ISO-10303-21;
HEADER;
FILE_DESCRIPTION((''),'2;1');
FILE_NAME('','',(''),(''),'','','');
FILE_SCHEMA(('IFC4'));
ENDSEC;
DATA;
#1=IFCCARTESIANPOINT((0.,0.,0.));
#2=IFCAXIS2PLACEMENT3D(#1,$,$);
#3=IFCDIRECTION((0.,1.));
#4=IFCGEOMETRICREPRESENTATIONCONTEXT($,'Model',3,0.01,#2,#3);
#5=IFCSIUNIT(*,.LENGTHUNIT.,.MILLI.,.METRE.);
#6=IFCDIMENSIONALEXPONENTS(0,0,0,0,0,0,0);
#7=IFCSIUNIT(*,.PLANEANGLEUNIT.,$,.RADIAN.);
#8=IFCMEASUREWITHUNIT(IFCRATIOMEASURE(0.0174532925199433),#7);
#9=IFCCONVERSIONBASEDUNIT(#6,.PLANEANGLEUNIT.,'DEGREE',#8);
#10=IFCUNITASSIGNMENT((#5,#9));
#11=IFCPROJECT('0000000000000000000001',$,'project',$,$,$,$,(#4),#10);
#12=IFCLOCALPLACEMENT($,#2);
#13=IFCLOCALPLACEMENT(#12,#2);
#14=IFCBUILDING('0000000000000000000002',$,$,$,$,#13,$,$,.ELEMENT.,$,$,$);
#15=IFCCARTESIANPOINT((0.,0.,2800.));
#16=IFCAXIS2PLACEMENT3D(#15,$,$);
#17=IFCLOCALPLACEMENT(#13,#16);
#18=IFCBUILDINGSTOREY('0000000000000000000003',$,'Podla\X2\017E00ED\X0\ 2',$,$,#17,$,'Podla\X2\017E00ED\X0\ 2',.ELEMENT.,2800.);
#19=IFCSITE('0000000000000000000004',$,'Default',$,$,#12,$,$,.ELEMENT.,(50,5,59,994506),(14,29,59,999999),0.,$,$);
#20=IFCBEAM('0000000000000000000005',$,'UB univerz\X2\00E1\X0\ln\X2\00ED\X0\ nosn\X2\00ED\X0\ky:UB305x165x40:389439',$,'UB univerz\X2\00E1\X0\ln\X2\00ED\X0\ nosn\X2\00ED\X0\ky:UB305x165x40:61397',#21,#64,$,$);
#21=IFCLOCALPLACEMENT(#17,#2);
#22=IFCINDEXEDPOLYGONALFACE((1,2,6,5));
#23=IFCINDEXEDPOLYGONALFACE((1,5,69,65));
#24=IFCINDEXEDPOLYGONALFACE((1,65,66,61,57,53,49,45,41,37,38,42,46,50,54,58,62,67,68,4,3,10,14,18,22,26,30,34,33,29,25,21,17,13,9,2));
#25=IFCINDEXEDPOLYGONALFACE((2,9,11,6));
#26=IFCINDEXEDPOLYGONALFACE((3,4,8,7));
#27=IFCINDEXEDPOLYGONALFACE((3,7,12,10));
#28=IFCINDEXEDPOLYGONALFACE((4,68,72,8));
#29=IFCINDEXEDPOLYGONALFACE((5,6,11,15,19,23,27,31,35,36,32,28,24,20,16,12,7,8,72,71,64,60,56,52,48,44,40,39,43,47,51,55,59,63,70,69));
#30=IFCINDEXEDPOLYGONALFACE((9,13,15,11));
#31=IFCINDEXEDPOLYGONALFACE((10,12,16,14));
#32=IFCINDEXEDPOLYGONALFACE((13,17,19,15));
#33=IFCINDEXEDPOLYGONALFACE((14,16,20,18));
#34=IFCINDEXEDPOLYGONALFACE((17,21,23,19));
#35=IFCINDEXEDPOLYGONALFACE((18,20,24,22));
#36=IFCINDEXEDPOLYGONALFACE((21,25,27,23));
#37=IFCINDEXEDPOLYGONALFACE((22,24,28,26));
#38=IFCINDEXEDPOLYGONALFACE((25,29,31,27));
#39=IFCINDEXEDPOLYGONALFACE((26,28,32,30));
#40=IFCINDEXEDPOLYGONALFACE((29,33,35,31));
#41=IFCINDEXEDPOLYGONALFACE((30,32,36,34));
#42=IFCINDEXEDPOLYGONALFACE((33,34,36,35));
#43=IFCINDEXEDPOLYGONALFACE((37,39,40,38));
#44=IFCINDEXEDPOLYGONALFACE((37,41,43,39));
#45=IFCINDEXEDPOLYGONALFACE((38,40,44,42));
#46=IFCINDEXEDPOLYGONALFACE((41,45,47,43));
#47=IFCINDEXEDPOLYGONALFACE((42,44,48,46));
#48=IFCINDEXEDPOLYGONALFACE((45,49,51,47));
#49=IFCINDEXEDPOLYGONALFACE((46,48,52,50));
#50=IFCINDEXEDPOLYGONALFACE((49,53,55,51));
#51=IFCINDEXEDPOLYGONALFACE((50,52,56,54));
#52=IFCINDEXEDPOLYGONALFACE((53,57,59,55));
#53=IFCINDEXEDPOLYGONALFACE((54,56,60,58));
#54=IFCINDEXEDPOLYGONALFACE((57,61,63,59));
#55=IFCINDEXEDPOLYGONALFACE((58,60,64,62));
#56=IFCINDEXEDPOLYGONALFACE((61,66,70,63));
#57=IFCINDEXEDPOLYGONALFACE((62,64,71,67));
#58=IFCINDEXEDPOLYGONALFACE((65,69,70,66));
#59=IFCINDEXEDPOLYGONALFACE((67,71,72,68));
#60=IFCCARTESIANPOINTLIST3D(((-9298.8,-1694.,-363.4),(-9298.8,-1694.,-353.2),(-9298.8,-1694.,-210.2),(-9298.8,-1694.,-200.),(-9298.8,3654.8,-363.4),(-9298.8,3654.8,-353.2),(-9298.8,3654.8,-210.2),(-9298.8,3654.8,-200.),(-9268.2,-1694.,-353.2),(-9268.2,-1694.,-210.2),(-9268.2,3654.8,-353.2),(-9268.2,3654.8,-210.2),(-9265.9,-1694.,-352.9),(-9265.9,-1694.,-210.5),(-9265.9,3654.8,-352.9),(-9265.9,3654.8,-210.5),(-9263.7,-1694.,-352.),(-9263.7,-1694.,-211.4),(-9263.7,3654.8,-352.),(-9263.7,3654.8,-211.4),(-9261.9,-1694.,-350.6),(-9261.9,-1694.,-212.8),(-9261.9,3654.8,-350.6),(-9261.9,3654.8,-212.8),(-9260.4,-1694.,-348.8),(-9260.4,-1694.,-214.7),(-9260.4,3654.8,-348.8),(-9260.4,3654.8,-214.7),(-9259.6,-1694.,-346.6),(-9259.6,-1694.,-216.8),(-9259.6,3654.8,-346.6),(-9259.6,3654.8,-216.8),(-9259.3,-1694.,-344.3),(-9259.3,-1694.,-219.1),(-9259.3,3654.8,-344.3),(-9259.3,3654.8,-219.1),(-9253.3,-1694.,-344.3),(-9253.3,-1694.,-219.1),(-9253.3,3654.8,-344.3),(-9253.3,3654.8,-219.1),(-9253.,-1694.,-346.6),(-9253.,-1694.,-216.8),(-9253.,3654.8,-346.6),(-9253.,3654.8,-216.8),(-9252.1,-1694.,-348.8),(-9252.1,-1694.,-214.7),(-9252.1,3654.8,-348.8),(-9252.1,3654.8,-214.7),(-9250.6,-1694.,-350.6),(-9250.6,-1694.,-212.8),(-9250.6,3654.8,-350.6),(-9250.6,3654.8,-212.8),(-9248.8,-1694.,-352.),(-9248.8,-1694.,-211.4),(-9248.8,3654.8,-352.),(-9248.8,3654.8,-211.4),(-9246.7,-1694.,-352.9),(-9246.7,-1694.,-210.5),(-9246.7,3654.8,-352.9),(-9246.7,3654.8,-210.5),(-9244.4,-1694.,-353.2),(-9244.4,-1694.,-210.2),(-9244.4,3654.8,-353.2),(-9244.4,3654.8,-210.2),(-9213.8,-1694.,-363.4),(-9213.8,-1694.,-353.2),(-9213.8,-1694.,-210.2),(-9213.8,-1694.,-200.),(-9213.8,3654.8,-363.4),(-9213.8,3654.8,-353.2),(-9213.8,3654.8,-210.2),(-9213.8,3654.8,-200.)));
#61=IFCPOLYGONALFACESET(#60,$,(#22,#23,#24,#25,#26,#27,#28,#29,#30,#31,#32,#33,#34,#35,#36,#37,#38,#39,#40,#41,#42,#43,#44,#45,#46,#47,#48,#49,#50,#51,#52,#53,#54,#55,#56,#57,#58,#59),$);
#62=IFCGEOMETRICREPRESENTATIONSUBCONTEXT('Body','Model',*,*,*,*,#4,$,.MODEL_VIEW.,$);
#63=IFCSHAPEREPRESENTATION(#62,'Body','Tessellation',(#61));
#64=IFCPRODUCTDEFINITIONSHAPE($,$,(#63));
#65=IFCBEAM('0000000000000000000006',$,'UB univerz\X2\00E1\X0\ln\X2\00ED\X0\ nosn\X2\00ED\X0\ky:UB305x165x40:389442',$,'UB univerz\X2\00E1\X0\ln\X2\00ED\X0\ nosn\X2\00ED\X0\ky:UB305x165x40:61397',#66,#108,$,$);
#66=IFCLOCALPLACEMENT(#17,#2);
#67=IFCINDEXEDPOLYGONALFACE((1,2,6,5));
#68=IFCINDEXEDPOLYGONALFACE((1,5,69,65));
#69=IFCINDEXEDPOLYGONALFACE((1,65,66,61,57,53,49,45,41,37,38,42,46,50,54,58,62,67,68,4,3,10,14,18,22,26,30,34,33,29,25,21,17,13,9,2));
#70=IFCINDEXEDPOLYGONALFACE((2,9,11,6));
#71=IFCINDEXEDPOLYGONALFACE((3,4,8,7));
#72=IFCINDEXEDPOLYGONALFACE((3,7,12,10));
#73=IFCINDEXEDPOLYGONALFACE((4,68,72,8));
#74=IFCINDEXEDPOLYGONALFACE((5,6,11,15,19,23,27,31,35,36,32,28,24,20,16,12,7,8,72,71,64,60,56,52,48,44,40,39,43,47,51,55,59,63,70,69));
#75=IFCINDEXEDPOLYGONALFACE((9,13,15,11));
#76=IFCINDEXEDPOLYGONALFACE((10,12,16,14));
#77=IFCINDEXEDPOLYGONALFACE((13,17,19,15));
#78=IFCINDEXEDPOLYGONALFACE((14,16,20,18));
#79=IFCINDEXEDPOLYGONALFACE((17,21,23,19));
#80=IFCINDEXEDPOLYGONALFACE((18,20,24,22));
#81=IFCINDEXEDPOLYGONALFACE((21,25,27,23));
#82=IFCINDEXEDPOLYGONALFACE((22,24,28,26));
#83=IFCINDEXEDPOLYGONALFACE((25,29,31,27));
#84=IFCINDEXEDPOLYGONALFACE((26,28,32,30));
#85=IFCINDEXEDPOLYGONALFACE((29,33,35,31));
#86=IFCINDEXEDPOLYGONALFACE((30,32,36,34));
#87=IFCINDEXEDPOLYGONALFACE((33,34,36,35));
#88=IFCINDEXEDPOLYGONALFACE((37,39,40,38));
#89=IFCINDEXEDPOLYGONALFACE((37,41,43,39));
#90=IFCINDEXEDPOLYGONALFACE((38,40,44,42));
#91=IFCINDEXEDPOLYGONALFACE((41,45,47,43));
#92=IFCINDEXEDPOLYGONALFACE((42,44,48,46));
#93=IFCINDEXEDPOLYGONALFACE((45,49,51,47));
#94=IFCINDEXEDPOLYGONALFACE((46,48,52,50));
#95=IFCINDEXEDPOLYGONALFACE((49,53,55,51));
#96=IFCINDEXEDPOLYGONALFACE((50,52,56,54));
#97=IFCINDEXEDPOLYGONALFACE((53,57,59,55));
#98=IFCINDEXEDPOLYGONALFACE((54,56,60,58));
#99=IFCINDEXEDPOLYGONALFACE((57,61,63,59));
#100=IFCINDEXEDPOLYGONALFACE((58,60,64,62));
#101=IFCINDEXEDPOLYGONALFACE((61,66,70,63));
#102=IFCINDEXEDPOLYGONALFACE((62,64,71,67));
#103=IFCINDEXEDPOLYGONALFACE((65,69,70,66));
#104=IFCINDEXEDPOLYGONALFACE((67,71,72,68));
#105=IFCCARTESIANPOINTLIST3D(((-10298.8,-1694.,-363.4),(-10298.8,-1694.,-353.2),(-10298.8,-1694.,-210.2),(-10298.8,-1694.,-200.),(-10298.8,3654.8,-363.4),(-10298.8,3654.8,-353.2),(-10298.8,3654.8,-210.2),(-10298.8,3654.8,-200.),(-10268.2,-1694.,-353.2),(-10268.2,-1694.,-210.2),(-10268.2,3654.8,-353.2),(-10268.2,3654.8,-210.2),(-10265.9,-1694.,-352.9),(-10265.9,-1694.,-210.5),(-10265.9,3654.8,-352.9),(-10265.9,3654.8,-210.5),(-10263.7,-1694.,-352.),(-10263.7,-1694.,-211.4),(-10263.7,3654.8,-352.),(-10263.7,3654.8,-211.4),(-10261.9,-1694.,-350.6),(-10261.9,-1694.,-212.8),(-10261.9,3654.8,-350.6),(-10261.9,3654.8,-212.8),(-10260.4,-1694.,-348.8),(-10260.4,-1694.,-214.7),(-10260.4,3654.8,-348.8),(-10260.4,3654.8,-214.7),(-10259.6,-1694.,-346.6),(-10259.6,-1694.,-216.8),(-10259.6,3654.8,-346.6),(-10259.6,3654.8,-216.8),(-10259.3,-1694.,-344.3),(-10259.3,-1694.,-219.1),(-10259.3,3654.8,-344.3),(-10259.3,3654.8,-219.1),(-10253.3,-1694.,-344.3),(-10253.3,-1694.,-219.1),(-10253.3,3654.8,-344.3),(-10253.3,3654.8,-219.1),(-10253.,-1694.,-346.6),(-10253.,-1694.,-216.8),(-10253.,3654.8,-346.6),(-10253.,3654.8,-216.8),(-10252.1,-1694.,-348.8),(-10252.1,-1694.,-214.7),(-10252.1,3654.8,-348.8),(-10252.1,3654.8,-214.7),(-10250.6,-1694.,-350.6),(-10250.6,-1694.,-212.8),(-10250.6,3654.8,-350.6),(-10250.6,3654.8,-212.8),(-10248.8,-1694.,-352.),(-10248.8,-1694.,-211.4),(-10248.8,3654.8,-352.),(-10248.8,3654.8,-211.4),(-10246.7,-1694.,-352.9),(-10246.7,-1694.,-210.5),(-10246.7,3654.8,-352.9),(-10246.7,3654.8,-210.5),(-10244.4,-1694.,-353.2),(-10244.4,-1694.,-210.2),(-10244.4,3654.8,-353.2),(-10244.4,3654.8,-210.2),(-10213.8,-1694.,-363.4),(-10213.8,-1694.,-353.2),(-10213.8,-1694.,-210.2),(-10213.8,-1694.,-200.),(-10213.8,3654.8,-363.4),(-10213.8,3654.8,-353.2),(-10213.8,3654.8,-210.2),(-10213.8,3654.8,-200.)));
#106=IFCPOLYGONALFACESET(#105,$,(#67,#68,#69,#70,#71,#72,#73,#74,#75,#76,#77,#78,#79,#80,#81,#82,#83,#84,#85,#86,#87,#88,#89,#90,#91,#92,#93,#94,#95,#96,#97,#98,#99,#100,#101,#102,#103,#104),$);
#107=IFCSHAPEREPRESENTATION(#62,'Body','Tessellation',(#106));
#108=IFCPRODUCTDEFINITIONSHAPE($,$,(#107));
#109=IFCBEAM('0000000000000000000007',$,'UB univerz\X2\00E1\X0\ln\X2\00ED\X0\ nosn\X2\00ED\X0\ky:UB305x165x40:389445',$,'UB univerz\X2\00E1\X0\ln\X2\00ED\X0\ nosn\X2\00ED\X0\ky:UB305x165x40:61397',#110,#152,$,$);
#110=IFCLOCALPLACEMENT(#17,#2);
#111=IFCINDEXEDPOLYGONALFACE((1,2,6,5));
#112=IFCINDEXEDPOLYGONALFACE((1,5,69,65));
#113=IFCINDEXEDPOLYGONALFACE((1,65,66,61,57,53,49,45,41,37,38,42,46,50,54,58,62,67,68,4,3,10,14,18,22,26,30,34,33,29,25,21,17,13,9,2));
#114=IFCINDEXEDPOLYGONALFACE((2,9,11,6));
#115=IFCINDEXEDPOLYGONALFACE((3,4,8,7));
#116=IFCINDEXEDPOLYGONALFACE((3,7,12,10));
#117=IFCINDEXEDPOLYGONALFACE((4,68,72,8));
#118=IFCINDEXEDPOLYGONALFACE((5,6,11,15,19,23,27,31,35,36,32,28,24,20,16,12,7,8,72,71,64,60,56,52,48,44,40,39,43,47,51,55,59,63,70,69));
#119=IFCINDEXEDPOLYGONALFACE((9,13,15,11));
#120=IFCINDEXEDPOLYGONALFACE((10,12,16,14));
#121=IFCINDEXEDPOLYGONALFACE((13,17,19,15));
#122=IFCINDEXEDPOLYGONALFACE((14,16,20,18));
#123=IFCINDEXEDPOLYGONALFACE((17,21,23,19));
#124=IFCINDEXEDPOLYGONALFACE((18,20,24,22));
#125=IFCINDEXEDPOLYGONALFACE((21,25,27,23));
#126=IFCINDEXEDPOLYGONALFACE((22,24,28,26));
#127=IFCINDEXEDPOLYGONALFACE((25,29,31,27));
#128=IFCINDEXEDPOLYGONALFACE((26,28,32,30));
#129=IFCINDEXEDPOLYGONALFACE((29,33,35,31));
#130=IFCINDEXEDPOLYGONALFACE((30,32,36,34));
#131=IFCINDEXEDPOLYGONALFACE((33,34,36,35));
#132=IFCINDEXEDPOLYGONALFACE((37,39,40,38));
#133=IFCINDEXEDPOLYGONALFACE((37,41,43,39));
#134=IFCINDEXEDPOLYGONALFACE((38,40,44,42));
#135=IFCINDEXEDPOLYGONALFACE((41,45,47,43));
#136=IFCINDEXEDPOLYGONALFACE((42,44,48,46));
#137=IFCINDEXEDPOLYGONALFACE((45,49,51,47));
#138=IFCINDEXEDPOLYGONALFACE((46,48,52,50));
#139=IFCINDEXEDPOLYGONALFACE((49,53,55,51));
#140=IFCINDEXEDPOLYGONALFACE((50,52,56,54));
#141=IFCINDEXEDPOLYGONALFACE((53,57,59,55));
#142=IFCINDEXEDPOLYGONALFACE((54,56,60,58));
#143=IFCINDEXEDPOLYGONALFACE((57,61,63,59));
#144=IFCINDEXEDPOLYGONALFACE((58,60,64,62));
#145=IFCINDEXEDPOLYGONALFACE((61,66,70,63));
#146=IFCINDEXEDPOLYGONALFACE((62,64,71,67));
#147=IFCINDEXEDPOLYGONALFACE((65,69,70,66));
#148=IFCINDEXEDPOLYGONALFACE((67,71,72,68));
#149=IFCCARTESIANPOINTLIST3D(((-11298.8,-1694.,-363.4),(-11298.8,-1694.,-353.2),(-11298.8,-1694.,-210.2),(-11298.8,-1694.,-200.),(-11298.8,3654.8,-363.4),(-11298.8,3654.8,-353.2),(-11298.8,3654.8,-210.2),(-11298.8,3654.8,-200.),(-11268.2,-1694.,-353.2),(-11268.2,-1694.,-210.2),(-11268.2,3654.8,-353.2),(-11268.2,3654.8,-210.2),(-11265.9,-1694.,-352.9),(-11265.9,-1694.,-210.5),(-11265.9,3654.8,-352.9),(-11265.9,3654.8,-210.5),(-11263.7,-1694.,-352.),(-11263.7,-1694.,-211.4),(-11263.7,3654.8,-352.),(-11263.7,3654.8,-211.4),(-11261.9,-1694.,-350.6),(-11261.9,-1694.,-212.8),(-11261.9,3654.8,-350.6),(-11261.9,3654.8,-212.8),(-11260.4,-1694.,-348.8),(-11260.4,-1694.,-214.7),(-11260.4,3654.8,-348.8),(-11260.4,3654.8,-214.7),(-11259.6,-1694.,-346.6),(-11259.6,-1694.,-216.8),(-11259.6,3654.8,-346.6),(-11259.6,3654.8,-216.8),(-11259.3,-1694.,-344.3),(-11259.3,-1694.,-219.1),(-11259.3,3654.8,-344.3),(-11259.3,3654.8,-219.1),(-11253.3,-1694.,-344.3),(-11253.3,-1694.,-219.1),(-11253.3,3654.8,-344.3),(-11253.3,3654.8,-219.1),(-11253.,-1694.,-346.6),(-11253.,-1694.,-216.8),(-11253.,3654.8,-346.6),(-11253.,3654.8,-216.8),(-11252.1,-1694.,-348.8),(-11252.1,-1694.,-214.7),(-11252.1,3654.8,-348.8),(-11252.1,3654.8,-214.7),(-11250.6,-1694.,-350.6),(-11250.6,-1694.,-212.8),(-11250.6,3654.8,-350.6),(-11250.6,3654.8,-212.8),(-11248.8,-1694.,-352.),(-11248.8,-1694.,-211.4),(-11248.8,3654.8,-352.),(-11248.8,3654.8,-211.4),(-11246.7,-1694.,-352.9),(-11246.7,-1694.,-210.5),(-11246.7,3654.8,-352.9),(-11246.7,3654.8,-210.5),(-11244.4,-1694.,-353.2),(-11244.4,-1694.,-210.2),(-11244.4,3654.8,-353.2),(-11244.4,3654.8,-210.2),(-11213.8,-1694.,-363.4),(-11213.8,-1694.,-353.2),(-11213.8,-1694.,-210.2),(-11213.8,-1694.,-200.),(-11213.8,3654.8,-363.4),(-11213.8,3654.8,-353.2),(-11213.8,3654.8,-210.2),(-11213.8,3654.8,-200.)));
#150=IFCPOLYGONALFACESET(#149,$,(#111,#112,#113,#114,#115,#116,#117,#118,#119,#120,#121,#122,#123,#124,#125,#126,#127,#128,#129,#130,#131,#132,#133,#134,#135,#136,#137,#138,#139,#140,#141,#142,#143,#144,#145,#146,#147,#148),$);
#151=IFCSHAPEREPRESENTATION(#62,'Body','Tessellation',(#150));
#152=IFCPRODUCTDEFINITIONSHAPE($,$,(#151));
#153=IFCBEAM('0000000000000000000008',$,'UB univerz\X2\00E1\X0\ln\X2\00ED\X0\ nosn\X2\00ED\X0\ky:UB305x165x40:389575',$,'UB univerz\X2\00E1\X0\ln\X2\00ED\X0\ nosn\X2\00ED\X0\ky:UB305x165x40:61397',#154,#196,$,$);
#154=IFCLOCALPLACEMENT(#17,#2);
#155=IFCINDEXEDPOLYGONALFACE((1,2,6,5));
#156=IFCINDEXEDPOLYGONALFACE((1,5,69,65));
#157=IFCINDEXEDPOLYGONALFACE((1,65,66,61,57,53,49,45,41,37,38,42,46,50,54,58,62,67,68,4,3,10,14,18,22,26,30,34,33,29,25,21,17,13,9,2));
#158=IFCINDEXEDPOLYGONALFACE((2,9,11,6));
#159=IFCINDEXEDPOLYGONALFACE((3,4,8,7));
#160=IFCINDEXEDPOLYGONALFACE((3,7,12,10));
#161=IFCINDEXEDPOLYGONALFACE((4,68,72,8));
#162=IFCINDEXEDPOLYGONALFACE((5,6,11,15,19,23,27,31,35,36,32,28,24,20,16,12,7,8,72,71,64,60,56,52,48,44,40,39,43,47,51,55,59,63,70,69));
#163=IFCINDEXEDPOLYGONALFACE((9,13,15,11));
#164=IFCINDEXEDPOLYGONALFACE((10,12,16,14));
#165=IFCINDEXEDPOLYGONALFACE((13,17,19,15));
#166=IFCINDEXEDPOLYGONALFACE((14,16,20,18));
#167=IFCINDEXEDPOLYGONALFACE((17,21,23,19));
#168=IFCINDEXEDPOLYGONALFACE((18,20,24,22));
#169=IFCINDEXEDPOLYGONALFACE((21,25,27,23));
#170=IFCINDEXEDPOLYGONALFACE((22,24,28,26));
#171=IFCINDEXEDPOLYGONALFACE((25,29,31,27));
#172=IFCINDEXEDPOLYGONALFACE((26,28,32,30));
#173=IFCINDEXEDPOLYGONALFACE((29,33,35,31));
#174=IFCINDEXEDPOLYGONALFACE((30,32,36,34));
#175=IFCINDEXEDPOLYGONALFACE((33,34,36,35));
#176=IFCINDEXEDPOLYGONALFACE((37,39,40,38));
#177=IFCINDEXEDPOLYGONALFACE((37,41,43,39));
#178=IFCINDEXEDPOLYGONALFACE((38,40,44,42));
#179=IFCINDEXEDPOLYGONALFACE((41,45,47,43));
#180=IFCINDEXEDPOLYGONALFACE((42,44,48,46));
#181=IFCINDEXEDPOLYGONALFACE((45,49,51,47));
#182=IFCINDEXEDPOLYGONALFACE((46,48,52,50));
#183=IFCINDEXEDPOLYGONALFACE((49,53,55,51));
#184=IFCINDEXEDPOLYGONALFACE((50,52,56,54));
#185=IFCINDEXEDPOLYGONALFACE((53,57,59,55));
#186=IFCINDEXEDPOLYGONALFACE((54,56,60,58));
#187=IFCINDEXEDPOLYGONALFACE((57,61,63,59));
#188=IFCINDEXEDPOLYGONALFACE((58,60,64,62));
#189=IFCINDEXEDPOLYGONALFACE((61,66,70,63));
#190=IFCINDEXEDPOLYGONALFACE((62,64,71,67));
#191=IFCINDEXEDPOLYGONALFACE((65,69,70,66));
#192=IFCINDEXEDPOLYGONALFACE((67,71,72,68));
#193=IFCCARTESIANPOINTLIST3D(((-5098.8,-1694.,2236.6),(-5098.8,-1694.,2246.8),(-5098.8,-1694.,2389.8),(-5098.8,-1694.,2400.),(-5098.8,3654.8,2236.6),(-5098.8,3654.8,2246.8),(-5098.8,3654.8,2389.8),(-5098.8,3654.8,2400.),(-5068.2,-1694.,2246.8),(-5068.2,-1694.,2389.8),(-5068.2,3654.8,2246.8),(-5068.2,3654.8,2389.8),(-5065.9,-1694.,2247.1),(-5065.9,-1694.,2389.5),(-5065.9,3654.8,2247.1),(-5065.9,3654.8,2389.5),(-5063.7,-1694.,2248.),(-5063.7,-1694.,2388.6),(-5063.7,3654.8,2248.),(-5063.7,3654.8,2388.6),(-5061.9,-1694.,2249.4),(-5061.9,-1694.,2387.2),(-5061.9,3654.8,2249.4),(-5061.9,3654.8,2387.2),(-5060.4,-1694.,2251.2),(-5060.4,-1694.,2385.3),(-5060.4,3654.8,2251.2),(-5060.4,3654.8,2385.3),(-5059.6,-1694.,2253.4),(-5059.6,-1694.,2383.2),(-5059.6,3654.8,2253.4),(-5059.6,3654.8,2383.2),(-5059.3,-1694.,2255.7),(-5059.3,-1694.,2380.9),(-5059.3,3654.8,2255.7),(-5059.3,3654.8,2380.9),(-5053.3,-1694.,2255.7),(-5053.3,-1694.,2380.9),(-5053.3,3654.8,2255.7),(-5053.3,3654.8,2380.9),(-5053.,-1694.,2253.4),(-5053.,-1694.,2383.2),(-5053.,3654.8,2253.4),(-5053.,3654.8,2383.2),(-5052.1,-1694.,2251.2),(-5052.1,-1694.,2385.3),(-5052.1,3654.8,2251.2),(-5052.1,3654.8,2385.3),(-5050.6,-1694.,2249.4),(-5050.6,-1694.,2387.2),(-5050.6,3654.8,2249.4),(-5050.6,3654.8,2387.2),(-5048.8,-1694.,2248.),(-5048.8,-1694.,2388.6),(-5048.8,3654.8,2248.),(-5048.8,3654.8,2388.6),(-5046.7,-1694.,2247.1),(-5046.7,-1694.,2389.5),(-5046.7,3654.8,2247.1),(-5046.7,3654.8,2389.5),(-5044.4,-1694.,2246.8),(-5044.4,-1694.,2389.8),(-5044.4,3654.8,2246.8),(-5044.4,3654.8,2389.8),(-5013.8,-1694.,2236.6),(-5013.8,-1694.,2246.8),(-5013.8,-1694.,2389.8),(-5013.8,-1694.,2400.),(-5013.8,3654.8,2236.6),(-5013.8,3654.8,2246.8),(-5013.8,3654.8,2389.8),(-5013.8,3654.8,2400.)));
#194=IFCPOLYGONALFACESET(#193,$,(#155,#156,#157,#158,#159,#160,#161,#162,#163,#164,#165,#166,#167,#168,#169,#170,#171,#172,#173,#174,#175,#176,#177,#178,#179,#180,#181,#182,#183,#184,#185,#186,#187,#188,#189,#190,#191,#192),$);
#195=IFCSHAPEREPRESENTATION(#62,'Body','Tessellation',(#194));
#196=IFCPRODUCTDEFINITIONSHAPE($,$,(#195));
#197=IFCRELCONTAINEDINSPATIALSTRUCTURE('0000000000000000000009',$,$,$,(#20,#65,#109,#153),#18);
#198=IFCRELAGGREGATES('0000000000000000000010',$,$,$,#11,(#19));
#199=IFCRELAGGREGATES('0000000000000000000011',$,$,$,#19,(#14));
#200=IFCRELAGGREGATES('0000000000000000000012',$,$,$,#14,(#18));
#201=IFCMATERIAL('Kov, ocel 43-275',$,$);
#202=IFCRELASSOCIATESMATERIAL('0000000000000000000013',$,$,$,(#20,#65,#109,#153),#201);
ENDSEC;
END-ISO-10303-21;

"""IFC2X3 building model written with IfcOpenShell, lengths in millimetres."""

from ifc_helpers import new_model, entity, si_unit, converted_unit, direction, frame, frame_2d, origin, place, context, subcontext, project, spatial, i_section, extrude, material, element, save


model = new_model("IFC2X3")

# Units and contexts
model_context = context("Model", 3, precision=0.01, world=origin(), true_north=direction((0.0, 1.0)))
body_context = subcontext(model_context, "Body", "Model", "MODEL_VIEW")
ifc_project = project(units=[si_unit("LENGTHUNIT", "METRE", prefix="MILLI"), converted_unit("PLANEANGLEUNIT", "DEGREE", entity("IfcRatioMeasure", 0.0174532925199433), si_unit("PLANEANGLEUNIT", "RADIAN"), dimensions=[0, 0, 0, 0, 0, 0, 0])], contexts=[model_context])

# Site, building, storey
site_placement = place(None, origin())
site = spatial("IfcSite", under=ifc_project, at=site_placement, Name="Default", CompositionType="ELEMENT", RefLatitude=(50, 5, 59, 994506), RefLongitude=(14, 29, 59, 999999), RefElevation=0.0)
building_placement = place(site_placement, origin())
building = spatial("IfcBuilding", under=site, at=building_placement, CompositionType="ELEMENT")
storey_placement = place(building_placement, frame((0.0, 0.0, 2800.0)))
storey = spatial("IfcBuildingStorey", under=building, at=storey_placement, Name="Podlaží 2", LongName="Podlaží 2", CompositionType="ELEMENT", Elevation=2800.0)

# Beams
ifc_material = material(Name="Kov, ocel 43-275")
for number, where, z_axis, x_axis, name in (
    (1, (-9256.3, 3654.8, 0.0), (0.0, 0.0, 1.0), (0.0, -1.0, 0.0), "UB univerzální nosníky:UB305x165x40:389439"),
):
    element("IfcBeam", number, at=place(storey_placement, frame(where, z_axis=z_axis, x_axis=x_axis)), inside=storey, material=ifc_material, Name=name, ObjectType="UB univerzální nosníky:UB305x165x40:61397", context=body_context, shape_type="SweptSolid", body=[
        extrude(i_section(OverallWidth=85.0, OverallDepth=163.4, WebThickness=6.0, FlangeThickness=10.2, FilletRadius=8.9, at=frame_2d((0.0, 0.0), x_axis=(0.0, 1.0))), frame((0.0, 0.0, -281.7), z_axis=(1.0, 0.0, 0.0), x_axis=(0.0, 0.0, -1.0)), (0.0, 0.0, 1.0), 5348.8),
    ])
beam_1_placement = place(storey_placement, frame((-10256.3, 3654.8, 0.0), z_axis=(0.0, 0.0, 1.0), x_axis=(0.0, -1.0, 0.0)))
element("IfcBeam", 2, at=beam_1_placement, inside=storey, material=ifc_material, Name="UB univerzální nosníky:UB305x165x40:389442", ObjectType="UB univerzální nosníky:UB305x165x40:61397", context=body_context, shape_type="SweptSolid", body=[
    extrude(i_section(OverallWidth=85.0, OverallDepth=163.4, WebThickness=6.0, FlangeThickness=10.2, FilletRadius=8.9, at=frame_2d((0.0, 0.0), x_axis=(0.0, 1.0))), frame((0.0, 0.0, -281.7), z_axis=(1.0, 0.0, 0.0), x_axis=(0.0, 0.0, -1.0)), (0.0, 0.0, 1.0), 5348.8),
])
beam_2_placement = place(storey_placement, frame((-11256.3, 3654.8, 0.0), z_axis=(0.0, 0.0, 1.0), x_axis=(0.0, -1.0, 0.0)))
element("IfcBeam", 3, at=beam_2_placement, inside=storey, material=ifc_material, Name="UB univerzální nosníky:UB305x165x40:389445", ObjectType="UB univerzální nosníky:UB305x165x40:61397", context=body_context, shape_type="SweptSolid", body=[
    extrude(i_section(OverallWidth=85.0, OverallDepth=163.4, WebThickness=6.0, FlangeThickness=10.2, FilletRadius=8.9, at=frame_2d((0.0, 0.0), x_axis=(0.0, 1.0))), frame((0.0, 0.0, -281.7), z_axis=(1.0, 0.0, 0.0), x_axis=(0.0, 0.0, -1.0)), (0.0, 0.0, 1.0), 5348.8),
])
beam_3_placement = place(storey_placement, frame((-5056.3, 3654.8, 0.0), z_axis=(0.0, 0.0, 1.0), x_axis=(0.0, -1.0, 0.0)))
element("IfcBeam", 4, at=beam_3_placement, inside=storey, material=ifc_material, Name="UB univerzální nosníky:UB305x165x40:389575", ObjectType="UB univerzální nosníky:UB305x165x40:61397", context=body_context, shape_type="SweptSolid", body=[
    extrude(i_section(OverallWidth=85.0, OverallDepth=163.4, WebThickness=6.0, FlangeThickness=10.2, FilletRadius=8.9, at=frame_2d((0.0, 0.0), x_axis=(0.0, 1.0))), frame((0.0, 0.0, 2318.3), z_axis=(1.0, 0.0, 0.0), x_axis=(0.0, 0.0, -1.0)), (0.0, 0.0, 1.0), 5348.8),
])

save(model, "model.ifc")
